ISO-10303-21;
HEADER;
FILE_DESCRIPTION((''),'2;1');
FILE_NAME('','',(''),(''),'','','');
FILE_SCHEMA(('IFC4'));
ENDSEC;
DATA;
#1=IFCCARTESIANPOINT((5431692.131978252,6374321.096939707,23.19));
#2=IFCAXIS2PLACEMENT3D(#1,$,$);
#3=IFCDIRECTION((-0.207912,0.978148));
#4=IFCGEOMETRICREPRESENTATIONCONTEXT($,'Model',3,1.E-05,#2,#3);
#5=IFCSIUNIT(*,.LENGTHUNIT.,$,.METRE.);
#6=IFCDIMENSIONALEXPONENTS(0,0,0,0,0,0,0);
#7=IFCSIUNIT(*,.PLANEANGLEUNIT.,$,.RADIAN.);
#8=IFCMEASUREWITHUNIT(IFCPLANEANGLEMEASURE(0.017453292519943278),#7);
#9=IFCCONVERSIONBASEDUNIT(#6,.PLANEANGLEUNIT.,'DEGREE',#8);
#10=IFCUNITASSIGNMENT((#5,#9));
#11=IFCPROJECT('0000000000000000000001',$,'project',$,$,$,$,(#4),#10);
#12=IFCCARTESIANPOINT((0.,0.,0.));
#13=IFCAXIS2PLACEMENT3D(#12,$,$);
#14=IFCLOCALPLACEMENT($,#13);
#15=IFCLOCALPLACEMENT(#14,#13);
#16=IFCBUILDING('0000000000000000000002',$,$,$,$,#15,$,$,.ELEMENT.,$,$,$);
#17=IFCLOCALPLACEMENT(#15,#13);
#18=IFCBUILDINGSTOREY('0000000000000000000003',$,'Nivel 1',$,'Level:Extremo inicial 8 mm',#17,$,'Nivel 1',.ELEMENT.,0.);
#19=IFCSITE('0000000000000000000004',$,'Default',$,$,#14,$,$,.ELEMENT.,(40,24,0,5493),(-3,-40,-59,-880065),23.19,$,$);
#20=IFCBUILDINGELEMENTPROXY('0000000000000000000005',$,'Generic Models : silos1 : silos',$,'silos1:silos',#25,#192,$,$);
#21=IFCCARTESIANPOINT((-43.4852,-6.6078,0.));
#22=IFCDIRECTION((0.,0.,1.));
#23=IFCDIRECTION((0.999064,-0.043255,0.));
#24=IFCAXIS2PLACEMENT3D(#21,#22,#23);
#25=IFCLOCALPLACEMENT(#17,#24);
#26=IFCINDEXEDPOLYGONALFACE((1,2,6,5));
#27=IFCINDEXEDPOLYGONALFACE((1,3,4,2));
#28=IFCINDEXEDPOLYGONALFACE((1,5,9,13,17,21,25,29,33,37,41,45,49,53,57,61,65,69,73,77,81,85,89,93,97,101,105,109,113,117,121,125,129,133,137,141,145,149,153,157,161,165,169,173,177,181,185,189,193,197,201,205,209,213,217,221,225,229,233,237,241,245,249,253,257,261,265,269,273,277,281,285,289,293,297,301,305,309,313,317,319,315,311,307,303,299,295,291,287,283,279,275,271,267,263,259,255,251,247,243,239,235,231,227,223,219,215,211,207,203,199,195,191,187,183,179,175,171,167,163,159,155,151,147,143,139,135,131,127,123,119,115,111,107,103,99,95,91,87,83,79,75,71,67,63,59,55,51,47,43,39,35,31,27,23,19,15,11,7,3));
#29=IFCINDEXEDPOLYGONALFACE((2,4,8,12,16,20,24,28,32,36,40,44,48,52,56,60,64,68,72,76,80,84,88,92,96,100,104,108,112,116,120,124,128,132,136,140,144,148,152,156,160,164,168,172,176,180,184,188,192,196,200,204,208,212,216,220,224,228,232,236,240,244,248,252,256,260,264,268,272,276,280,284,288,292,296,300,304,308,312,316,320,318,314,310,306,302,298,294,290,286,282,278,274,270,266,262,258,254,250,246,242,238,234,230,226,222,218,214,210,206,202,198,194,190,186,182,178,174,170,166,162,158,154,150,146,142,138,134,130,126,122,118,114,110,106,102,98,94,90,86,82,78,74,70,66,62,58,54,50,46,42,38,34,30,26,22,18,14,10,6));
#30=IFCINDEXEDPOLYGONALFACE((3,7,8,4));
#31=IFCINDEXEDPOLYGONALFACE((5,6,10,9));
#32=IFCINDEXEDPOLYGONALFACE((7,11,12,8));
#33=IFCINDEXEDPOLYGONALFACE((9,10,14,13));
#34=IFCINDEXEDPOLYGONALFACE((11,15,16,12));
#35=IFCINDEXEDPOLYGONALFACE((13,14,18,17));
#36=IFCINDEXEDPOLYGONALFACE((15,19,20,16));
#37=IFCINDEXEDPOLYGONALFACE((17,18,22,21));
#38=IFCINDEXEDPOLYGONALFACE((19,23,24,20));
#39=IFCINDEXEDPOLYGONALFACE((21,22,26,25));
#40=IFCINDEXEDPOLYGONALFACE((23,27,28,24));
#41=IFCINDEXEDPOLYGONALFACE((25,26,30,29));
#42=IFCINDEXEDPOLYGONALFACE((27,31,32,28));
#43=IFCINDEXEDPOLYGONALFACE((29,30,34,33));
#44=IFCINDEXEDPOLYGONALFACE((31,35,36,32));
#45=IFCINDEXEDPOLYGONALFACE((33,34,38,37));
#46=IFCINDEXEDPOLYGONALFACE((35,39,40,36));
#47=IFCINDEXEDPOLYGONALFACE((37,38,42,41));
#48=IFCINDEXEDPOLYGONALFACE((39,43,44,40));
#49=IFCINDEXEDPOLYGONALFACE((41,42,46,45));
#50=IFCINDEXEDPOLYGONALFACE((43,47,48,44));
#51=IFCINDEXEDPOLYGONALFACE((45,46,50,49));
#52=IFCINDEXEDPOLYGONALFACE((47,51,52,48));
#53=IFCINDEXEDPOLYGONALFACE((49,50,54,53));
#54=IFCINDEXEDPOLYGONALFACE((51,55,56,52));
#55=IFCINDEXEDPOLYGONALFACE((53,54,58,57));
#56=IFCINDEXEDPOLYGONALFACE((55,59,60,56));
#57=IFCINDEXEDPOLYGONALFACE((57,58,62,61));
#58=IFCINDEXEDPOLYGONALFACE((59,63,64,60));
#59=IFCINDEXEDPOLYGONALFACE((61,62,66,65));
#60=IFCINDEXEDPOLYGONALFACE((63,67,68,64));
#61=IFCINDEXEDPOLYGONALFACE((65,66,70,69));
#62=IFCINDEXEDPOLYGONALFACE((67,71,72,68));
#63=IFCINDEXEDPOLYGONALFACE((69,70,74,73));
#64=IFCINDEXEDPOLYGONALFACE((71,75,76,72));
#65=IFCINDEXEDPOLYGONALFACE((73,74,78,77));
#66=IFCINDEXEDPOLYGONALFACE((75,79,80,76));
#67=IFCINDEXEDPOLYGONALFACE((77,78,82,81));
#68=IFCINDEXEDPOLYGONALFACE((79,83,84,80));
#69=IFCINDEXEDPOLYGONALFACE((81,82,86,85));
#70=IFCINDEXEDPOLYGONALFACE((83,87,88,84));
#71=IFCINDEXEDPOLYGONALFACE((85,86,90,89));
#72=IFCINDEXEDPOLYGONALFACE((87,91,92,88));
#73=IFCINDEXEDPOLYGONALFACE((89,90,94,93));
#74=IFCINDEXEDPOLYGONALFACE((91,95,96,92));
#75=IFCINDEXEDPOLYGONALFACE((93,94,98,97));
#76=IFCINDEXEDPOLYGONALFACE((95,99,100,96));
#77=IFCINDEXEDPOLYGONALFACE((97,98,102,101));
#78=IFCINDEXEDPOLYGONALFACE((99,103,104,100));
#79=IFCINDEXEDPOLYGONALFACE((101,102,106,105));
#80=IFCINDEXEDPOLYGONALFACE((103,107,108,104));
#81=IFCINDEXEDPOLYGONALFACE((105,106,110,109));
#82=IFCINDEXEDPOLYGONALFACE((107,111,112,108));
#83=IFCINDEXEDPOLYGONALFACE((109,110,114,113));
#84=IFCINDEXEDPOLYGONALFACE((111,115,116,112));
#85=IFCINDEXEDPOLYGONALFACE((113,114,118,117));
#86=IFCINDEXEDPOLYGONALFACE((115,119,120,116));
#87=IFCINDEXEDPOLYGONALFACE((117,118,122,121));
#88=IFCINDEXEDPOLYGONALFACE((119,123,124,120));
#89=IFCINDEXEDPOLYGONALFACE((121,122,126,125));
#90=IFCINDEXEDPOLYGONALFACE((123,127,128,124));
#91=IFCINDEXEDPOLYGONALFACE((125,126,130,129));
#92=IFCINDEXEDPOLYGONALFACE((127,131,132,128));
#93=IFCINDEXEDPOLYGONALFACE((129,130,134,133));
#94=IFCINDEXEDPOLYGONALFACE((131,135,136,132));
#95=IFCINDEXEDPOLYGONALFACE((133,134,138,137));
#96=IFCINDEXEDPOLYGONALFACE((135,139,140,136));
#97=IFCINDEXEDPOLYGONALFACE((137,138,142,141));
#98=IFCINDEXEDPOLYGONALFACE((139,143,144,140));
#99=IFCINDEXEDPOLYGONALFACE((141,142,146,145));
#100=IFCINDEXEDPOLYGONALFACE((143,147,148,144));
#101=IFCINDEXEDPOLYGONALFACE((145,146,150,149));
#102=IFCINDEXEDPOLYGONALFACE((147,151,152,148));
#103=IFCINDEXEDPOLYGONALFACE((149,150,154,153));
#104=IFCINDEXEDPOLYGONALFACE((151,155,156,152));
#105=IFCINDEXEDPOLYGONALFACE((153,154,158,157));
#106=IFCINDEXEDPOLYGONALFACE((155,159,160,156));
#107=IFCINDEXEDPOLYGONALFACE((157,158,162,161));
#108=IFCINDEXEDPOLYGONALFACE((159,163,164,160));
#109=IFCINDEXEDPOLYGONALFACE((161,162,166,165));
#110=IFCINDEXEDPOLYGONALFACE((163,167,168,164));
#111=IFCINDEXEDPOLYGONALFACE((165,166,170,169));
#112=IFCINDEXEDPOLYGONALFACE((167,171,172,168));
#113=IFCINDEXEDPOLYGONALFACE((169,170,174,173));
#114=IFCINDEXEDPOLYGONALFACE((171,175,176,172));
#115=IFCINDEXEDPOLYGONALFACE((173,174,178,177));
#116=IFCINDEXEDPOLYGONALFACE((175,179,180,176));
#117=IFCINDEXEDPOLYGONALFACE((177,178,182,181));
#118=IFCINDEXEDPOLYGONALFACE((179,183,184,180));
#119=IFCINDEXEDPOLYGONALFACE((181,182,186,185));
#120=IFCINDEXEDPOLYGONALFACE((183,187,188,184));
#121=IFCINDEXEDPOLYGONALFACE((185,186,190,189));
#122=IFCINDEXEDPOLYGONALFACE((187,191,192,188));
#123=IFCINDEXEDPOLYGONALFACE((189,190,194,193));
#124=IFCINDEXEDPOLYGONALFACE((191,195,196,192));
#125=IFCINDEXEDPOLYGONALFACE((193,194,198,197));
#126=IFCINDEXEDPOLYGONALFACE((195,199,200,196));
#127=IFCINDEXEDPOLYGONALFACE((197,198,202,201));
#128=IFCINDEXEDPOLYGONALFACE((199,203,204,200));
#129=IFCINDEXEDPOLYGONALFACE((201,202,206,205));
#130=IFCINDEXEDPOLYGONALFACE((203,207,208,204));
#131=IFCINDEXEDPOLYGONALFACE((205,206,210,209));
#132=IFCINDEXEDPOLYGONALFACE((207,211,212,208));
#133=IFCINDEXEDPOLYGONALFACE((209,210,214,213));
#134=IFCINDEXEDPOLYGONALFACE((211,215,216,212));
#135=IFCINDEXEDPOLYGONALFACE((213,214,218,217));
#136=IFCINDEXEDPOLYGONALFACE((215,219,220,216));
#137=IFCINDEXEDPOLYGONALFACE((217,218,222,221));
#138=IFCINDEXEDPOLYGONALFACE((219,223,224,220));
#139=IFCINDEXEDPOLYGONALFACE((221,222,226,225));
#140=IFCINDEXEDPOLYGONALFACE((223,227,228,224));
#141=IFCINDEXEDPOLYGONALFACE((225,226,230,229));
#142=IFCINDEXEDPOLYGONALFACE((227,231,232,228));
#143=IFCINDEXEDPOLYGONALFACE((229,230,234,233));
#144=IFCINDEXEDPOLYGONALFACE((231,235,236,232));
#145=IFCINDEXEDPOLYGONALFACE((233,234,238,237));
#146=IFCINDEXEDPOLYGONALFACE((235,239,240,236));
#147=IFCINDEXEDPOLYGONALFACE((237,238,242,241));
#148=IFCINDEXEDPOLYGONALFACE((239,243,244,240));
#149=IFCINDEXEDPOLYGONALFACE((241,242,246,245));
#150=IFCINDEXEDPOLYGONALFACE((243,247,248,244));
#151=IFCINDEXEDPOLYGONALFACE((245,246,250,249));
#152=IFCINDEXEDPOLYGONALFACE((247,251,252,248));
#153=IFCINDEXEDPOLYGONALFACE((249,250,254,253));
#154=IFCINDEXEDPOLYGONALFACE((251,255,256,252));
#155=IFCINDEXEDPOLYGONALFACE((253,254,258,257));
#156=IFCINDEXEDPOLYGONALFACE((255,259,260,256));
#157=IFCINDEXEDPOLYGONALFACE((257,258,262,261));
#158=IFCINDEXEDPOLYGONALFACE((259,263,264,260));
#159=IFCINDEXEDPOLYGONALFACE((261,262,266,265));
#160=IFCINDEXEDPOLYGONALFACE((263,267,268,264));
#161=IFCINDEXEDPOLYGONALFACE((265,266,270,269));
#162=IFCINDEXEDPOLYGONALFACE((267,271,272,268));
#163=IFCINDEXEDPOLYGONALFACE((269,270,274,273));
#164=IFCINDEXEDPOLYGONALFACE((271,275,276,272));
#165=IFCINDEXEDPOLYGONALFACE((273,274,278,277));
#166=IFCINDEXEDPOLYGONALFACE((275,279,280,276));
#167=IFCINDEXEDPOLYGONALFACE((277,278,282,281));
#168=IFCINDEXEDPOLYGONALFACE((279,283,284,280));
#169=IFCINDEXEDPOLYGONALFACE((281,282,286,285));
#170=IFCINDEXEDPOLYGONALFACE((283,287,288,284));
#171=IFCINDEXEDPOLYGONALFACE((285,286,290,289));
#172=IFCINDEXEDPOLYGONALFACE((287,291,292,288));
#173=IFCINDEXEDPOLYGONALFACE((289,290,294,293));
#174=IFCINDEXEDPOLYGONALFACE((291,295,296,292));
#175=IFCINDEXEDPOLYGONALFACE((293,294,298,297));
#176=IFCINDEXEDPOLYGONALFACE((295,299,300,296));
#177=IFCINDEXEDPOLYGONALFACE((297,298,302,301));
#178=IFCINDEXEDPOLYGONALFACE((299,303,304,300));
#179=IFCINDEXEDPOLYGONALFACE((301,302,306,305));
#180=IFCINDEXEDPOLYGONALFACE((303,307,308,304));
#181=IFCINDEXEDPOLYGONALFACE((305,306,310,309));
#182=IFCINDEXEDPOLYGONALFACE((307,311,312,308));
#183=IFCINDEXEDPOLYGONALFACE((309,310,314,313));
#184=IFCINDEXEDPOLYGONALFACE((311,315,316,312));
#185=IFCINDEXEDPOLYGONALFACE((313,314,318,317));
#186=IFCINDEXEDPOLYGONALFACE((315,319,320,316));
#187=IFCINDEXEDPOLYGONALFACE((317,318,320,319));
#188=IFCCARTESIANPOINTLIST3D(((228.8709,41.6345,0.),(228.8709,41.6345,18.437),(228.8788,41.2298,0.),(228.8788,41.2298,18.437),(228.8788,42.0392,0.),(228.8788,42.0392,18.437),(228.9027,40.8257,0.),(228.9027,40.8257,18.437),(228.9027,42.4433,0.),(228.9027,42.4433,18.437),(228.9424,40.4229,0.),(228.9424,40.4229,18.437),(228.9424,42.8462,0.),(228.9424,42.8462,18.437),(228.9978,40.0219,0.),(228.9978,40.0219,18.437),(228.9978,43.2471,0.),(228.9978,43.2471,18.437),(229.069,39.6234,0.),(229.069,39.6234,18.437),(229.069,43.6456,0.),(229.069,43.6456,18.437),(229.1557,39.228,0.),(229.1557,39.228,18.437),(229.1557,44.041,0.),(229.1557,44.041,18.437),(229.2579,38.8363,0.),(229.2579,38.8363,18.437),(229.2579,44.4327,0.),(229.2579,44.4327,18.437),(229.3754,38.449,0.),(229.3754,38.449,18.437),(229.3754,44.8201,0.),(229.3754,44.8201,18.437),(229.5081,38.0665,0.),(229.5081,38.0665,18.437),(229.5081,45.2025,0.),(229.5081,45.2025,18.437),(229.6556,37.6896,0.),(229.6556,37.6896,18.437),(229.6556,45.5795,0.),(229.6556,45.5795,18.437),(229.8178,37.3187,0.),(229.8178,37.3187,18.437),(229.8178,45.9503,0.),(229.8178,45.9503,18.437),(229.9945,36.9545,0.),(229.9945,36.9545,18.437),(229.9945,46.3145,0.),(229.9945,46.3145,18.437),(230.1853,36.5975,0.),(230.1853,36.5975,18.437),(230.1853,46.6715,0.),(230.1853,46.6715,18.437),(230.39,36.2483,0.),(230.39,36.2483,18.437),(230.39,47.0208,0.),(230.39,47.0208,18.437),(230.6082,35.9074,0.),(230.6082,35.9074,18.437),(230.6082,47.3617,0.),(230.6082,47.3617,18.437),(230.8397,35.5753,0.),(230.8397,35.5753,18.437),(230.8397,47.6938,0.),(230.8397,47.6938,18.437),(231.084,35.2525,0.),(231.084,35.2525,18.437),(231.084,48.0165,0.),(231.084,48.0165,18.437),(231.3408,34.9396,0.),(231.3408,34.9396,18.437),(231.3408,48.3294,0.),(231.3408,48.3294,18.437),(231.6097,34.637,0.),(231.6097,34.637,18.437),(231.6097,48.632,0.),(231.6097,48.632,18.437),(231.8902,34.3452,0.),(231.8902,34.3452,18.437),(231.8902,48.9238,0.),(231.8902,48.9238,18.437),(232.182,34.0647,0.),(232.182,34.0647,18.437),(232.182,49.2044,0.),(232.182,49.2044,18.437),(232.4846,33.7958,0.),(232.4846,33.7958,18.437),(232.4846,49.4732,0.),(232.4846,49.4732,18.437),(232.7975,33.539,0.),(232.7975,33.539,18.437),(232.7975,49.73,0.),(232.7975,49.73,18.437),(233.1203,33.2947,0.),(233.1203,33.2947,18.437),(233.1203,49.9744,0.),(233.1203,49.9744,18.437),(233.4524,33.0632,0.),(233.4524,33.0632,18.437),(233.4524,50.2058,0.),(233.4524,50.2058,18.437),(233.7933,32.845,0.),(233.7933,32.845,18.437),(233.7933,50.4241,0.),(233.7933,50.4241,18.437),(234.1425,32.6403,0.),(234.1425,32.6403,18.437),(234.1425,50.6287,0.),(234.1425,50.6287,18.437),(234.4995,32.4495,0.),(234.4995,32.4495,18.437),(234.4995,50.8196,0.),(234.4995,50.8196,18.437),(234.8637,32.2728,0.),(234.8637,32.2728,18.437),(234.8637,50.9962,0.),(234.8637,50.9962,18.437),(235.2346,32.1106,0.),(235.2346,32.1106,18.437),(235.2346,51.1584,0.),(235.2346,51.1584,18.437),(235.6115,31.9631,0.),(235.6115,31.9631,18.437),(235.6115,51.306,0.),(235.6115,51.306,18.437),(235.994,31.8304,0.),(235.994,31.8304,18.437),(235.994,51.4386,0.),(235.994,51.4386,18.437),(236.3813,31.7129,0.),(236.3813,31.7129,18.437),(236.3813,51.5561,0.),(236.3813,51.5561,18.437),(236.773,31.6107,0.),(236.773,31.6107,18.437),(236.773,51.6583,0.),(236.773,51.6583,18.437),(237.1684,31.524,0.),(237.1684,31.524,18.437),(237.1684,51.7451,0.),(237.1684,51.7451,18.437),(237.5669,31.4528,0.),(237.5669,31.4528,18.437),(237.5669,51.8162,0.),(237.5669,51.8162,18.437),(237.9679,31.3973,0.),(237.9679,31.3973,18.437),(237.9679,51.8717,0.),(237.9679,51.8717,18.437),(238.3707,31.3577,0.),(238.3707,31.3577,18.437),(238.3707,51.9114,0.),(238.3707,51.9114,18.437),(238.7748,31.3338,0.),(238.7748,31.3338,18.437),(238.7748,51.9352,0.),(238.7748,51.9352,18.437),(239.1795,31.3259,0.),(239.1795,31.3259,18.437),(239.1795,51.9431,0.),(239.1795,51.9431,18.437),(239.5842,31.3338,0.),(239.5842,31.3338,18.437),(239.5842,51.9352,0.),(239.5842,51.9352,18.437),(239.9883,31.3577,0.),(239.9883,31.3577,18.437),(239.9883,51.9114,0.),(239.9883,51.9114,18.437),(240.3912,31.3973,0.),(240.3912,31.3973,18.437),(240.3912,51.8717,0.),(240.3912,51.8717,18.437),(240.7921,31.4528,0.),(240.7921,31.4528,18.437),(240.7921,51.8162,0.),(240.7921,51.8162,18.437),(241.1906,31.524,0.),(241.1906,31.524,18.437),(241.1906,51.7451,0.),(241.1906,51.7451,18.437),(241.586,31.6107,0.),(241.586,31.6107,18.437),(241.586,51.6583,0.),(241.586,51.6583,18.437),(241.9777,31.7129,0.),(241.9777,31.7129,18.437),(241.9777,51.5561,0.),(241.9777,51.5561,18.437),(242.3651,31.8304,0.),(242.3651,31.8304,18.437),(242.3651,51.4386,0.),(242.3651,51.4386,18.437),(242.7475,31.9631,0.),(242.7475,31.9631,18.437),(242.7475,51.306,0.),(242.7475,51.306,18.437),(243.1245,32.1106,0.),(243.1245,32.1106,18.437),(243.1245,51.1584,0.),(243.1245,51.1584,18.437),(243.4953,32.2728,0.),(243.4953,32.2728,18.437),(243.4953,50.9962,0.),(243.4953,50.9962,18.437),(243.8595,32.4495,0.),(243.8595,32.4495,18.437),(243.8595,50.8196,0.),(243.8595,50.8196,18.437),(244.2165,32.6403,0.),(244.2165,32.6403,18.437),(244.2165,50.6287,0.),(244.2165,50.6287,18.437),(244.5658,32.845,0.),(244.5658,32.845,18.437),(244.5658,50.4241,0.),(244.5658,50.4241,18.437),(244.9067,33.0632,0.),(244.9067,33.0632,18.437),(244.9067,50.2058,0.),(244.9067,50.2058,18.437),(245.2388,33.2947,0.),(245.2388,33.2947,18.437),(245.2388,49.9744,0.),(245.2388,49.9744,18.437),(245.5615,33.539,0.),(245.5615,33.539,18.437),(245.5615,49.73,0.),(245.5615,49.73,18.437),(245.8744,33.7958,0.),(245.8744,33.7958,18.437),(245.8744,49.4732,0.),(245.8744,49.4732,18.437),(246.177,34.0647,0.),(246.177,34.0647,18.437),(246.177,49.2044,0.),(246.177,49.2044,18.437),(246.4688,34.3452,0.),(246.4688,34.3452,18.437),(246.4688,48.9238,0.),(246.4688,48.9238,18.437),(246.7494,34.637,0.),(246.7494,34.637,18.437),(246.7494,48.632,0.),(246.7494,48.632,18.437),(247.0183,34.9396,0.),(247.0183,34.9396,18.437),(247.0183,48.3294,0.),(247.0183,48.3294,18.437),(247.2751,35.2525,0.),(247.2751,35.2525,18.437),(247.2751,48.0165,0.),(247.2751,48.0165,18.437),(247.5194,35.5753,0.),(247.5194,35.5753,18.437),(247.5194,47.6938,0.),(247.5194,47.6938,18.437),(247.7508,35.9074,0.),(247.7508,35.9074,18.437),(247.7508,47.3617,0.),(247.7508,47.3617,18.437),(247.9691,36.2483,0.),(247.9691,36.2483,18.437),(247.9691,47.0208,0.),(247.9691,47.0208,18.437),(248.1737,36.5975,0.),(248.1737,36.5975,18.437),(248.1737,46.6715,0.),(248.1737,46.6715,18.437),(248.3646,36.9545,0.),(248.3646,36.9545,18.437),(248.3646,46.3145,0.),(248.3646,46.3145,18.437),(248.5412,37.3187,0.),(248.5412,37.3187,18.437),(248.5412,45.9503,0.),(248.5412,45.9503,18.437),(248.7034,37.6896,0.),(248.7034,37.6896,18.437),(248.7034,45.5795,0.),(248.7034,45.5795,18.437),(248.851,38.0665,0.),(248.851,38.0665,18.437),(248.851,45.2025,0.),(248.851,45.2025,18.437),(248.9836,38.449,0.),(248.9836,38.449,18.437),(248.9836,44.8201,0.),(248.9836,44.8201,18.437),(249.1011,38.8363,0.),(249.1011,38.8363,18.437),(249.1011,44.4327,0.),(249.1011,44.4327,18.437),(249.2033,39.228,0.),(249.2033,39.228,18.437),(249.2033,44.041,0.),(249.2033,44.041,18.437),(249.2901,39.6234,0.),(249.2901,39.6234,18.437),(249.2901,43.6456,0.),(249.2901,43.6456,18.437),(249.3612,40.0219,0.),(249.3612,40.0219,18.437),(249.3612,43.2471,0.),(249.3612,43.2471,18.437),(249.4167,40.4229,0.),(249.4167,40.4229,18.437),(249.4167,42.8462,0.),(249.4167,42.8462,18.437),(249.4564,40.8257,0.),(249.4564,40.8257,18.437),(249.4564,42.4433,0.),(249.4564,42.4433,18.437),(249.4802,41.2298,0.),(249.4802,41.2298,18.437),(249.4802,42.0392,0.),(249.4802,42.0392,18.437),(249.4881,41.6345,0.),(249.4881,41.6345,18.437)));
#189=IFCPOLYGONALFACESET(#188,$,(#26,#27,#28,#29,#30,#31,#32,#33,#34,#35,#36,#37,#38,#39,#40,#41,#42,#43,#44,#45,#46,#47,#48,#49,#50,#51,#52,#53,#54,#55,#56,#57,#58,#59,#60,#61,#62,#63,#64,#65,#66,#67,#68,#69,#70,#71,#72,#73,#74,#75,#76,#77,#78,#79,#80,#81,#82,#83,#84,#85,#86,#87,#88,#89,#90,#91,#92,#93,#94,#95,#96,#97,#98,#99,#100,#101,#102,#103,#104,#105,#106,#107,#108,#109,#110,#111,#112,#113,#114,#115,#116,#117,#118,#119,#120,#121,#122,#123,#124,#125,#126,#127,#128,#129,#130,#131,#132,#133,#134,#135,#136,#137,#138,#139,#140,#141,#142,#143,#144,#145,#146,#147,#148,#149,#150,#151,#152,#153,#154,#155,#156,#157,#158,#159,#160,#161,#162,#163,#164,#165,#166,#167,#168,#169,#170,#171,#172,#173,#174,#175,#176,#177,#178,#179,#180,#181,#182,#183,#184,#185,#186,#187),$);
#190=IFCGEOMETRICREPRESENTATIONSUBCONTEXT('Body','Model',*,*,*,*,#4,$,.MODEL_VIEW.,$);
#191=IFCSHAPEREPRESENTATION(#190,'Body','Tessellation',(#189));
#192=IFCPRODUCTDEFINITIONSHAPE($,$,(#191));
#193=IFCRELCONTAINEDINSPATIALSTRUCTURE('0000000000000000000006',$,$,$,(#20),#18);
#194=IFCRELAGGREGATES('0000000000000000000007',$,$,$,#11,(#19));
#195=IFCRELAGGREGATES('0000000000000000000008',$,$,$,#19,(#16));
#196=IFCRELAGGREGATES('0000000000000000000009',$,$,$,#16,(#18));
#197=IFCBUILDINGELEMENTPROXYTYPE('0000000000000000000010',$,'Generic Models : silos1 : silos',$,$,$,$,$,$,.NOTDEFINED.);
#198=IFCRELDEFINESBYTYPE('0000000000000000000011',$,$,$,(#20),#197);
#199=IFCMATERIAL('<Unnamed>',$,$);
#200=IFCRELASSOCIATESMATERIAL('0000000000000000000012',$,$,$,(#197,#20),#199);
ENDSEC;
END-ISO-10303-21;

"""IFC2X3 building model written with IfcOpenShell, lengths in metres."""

from ifc_helpers import new_model, entity, si_unit, converted_unit, direction, frame, frame_2d, origin, place, context, subcontext, project, spatial, circle, extrude, source, transform, mapped, material, type_object, type_shapes, element, save


model = new_model("IFC2X3")

# Units and contexts
model_context = context("Model", 3, precision=1e-05, world=frame((5431692.131978252, 6374321.096939707, 23.19)), true_north=direction((-0.207912, 0.978148)))
body_context = subcontext(model_context, "Body", "Model", "MODEL_VIEW")
ifc_project = project(units=[si_unit("LENGTHUNIT", "METRE"), converted_unit("PLANEANGLEUNIT", "DEGREE", entity("IfcPlaneAngleMeasure", 0.017453292519943278), si_unit("PLANEANGLEUNIT", "RADIAN"), dimensions=[0, 0, 0, 0, 0, 0, 0])], contexts=[model_context])

# Site, building, storey
site_placement = place(None, origin())
site = spatial("IfcSite", under=ifc_project, at=site_placement, Name="Default", CompositionType="ELEMENT", RefLatitude=(40, 24, 0, 5493), RefLongitude=(-3, -40, -59, -880065), RefElevation=23.19)
building_placement = place(site_placement, origin())
building = spatial("IfcBuilding", under=site, at=building_placement, CompositionType="ELEMENT")
storey_placement = place(building_placement, origin())
storey = spatial("IfcBuildingStorey", under=building, at=storey_placement, Name="Nivel 1", ObjectType="Level:Extremo inicial 8 mm", LongName="Nivel 1", CompositionType="ELEMENT", Elevation=0.0)

# Building element proxy
ifc_material_1 = material(Name="<Unnamed>")
building_element_proxy_type_1 = type_object("IfcBuildingElementProxyType", Name="Generic Models : silos1 : silos", PredefinedType="NOTDEFINED", material=ifc_material_1)
shared_shape_1 = source(origin(), body_context, "Body", "SweptSolid", [
    extrude(circle(Radius=10.3086, at=frame_2d((0.0, 0.0), x_axis=(1.0, 0.0))), frame((239.1795, 41.6345, 0.0)), (0.0, 0.0, 1.0), 18.437),
])
type_shapes(building_element_proxy_type_1, [shared_shape_1])
proxy_1_placement = place(storey_placement, frame((-43.4852, -6.6078, 0.0), z_axis=(0.0, 0.0, 1.0), x_axis=(0.999064, -0.043255, 0.0)))
element("IfcBuildingElementProxy", 1, at=proxy_1_placement, inside=storey, type_object=building_element_proxy_type_1, material=ifc_material_1, Name="Generic Models : silos1 : silos", ObjectType="silos1:silos", context=body_context, shape_type="MappedRepresentation", body=[
    mapped(shared_shape_1, transform((0.0, 0.0, 0.0), scale=1.0)),
])

save(model, "model.ifc")
